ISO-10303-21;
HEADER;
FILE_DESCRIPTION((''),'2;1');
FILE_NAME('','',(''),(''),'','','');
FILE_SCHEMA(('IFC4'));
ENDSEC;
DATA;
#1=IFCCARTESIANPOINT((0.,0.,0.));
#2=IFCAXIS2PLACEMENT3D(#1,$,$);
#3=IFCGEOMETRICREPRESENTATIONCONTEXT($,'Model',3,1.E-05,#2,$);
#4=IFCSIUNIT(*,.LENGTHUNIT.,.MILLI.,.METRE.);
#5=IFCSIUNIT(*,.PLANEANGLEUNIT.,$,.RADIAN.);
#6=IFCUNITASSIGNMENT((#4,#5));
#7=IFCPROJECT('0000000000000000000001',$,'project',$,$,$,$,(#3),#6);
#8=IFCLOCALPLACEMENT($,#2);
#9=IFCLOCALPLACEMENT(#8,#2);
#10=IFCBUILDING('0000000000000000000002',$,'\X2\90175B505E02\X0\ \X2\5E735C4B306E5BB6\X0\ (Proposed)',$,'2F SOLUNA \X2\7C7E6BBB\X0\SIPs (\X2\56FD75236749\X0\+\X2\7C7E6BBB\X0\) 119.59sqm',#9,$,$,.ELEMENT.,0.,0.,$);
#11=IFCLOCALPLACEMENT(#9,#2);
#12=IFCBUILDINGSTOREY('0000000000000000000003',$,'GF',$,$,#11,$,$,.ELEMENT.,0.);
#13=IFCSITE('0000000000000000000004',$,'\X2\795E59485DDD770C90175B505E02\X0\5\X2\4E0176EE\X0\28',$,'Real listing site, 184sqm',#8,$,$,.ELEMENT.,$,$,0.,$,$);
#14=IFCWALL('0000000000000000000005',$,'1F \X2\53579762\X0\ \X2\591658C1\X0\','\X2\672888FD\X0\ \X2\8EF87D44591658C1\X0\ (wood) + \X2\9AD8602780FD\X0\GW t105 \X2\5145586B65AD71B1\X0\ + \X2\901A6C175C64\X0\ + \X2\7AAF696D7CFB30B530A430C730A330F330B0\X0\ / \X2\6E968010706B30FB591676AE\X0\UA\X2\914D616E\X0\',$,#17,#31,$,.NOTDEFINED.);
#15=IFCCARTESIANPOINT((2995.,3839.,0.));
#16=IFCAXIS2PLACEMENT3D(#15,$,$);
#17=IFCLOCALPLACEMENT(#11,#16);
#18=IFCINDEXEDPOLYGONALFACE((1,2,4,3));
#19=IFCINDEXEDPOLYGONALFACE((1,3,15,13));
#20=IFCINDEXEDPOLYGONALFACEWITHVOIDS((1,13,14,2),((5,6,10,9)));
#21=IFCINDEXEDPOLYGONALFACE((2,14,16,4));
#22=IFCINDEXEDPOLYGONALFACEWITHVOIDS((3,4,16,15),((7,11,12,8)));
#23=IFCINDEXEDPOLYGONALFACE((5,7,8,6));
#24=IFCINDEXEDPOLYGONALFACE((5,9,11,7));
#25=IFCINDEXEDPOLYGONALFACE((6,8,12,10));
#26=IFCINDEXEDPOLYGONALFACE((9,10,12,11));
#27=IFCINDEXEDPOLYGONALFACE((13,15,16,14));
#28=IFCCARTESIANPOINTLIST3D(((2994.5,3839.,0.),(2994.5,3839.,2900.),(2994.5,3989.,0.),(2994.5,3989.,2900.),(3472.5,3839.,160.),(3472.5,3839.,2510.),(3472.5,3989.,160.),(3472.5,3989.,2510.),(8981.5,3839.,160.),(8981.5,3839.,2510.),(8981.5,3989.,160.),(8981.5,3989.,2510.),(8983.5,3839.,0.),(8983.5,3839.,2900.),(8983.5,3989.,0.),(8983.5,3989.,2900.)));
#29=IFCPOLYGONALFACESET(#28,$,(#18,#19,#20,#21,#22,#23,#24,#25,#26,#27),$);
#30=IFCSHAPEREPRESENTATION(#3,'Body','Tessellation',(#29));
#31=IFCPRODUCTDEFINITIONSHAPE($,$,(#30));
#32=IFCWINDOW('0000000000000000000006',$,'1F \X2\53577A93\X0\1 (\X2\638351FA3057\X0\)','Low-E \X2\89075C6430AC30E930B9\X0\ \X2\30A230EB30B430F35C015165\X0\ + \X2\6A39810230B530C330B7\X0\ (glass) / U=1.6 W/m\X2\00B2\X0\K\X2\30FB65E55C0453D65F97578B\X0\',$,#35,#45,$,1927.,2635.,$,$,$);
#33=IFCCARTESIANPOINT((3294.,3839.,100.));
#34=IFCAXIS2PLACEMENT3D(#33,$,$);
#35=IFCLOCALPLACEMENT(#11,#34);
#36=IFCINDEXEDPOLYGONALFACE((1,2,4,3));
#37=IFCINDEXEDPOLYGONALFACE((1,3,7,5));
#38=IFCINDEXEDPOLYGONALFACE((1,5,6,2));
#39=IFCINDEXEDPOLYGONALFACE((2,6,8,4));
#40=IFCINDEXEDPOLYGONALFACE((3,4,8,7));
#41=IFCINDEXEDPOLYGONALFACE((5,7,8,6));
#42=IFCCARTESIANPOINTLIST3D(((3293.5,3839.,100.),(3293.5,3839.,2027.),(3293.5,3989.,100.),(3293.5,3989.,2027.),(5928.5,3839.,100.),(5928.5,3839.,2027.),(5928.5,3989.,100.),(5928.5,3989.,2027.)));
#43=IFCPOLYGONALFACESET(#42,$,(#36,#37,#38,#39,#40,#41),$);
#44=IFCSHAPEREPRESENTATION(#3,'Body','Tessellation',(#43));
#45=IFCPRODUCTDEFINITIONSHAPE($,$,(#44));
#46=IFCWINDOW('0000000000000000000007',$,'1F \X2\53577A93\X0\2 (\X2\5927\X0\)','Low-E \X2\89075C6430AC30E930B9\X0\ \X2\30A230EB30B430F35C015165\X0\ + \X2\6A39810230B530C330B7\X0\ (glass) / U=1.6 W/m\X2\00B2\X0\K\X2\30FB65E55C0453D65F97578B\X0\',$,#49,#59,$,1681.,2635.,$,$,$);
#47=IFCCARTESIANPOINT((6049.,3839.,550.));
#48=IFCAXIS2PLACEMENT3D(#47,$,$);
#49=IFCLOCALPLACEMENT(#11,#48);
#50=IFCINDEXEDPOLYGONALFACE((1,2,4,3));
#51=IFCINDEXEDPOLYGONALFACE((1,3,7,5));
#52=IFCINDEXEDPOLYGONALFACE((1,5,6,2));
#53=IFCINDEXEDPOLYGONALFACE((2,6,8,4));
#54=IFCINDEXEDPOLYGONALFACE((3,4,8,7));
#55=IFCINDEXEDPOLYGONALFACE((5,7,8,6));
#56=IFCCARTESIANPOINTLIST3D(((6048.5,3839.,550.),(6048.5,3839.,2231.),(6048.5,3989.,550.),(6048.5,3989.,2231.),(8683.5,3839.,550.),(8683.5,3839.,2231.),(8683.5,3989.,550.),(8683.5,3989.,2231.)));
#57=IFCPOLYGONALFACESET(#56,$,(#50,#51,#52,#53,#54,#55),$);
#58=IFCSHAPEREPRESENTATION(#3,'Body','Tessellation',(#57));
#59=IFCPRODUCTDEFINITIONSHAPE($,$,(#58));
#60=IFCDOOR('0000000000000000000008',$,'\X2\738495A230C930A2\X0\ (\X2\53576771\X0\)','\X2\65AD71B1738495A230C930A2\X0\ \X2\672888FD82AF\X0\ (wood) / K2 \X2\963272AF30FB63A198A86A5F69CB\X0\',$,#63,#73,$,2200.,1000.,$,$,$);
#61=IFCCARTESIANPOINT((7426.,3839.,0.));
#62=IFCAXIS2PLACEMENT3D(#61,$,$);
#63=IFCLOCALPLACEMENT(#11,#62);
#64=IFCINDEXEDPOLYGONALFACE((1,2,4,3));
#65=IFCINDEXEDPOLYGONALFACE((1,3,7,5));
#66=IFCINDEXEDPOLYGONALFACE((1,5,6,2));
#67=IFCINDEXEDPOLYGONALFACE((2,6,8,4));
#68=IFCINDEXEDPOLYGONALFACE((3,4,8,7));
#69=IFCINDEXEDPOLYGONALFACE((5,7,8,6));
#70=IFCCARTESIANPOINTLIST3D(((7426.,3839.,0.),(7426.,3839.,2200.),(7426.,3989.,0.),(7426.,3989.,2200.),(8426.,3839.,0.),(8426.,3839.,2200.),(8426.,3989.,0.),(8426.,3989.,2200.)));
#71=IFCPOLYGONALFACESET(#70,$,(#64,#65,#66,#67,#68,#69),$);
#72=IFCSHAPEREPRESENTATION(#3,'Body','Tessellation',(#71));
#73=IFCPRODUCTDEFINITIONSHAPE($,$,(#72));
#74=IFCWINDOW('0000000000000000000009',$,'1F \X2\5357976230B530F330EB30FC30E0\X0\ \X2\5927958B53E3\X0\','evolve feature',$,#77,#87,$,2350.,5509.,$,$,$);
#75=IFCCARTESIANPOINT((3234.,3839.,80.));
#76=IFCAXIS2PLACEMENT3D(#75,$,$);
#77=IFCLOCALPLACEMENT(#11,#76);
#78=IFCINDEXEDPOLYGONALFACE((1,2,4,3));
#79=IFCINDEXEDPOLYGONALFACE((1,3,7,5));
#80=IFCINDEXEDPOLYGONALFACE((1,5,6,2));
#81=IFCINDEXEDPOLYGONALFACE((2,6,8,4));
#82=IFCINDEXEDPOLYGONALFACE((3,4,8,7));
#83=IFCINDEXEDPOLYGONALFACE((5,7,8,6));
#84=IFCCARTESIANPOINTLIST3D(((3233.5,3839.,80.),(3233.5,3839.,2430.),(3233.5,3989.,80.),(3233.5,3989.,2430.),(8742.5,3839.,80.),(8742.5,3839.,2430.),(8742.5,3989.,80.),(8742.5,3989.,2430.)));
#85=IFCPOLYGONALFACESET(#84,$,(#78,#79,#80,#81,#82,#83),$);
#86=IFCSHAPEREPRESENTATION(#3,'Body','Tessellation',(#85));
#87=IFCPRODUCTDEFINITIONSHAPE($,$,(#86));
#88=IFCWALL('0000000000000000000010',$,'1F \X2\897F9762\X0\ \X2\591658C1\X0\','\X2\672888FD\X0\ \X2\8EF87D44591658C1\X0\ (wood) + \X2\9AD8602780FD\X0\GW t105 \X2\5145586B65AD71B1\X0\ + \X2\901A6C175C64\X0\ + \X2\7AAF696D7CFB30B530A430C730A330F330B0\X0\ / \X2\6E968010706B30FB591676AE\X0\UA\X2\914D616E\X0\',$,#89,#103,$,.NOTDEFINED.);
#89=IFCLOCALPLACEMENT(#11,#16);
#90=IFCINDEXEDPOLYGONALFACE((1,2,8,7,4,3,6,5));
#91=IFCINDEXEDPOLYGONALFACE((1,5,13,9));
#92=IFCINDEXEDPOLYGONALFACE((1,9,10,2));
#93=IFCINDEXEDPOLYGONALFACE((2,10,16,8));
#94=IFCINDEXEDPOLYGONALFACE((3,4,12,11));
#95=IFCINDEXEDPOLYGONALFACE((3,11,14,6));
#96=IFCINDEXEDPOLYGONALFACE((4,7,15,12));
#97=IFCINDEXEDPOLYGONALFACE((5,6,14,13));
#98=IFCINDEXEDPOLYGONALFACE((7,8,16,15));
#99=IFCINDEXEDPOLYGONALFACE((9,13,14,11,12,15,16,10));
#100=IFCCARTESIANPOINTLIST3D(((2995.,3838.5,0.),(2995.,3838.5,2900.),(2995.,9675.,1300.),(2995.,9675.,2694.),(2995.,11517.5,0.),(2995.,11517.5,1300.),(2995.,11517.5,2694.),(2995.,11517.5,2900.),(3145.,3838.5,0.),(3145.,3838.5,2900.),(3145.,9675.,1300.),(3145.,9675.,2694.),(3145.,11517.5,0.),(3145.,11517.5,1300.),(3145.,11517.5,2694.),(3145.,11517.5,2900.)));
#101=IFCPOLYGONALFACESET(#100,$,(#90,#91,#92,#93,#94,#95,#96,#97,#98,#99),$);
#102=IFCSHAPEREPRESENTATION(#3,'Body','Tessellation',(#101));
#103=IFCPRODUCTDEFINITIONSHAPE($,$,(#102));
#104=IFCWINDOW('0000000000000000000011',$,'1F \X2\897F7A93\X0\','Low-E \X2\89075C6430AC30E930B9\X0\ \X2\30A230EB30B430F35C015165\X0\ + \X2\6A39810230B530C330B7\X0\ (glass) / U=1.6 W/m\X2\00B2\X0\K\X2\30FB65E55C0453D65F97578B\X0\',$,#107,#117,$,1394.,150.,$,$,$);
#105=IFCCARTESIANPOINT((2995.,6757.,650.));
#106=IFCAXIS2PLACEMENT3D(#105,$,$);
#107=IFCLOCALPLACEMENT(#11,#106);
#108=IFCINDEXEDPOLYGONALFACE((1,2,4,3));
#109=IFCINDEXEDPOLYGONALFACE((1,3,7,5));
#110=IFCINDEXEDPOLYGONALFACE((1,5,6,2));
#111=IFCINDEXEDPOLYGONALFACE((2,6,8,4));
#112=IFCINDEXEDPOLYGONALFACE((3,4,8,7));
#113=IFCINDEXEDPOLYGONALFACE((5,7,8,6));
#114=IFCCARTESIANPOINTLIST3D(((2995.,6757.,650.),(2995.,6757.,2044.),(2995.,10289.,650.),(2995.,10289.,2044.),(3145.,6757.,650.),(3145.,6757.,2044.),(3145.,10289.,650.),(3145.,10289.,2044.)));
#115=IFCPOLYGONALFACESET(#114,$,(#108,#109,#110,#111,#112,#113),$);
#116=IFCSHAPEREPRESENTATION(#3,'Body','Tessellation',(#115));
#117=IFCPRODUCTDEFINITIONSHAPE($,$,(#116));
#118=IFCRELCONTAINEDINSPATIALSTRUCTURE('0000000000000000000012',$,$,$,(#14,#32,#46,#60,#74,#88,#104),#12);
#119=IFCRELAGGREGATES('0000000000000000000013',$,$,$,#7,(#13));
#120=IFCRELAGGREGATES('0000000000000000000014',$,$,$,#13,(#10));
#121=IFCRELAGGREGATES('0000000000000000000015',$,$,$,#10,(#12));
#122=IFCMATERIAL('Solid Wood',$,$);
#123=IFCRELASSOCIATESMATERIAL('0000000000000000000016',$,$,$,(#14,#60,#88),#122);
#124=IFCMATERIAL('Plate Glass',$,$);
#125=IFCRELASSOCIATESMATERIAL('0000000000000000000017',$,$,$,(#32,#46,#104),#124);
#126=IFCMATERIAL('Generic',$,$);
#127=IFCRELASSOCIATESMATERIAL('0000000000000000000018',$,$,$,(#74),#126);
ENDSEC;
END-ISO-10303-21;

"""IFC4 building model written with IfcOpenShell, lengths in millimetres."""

from ifc_helpers import new_model, si_unit, frame, frame_2d, origin, place, context, project, spatial, rectangle, extrude, material, element, fill, save


model = new_model("IFC4")

# Units and contexts
model_context = context("Model", 3, precision=1e-05, world=origin())
ifc_project = project(units=[si_unit("LENGTHUNIT", "METRE", prefix="MILLI"), si_unit("PLANEANGLEUNIT", "RADIAN")], contexts=[model_context])

# Site, building, storey
site_placement = place(None, origin())
site = spatial("IfcSite", under=ifc_project, at=site_placement, Name="神奈川県逗子市5丁目28", ObjectType="Real listing site, 184sqm", CompositionType="ELEMENT", RefElevation=0.0)
building_placement = place(site_placement, origin())
building = spatial("IfcBuilding", under=site, at=building_placement, Name="逗子市 平屋の家 (Proposed)", ObjectType="2F SOLUNA 籾殻SIPs (国産杉+籾殻) 119.59sqm", CompositionType="ELEMENT", ElevationOfRefHeight=0.0, ElevationOfTerrain=0.0)
storey_placement = place(building_placement, origin())
storey = spatial("IfcBuildingStorey", under=building, at=storey_placement, Name="GF", CompositionType="ELEMENT", Elevation=0.0)

# Shared definitions
ifc_material_1 = material(Name="Solid Wood")
ifc_material_2 = material(Name="Generic")

# Wall, openings, windows, door
wall_1_placement = place(storey_placement, frame((2995.0, 3839.0, 0.0)))
wall_1 = element("IfcWall", 1, at=wall_1_placement, inside=storey, material=ifc_material_1, Name="1F 南面 外壁", Description="木製 軸組外壁 (wood) + 高性能GW t105 充填断熱 + 通気層 + 窯業系サイディング / 準耐火・外皮UA配慮", PredefinedType="NOTDEFINED", context=model_context, shape_type="SweptSolid", body=[
    extrude(rectangle(XDim=5989.0, YDim=150.0, at=frame_2d((2994.0, 75.0))), frame((2995.0, 3839.0, 0.0)), (0.0, 0.0, 1.0), 2900.0),
])
opening_1_placement = place(storey_placement, frame((3294.0, 3839.0, 100.0)))
opening_1 = element("IfcOpeningElement", 2, at=opening_1_placement, cuts=wall_1, PredefinedType="NOTDEFINED", context=model_context, shape_type="SweptSolid", body=[
    extrude(rectangle(XDim=2635.0, YDim=150.0, at=frame_2d((1317.0, 75.0))), frame((3294.0, 3839.0, 100.0)), (0.0, 0.0, 1.0), 1927.0),
])
opening_2_placement = place(storey_placement, frame((6049.0, 3839.0, 550.0)))
opening_2 = element("IfcOpeningElement", 3, at=opening_2_placement, cuts=wall_1, PredefinedType="NOTDEFINED", context=model_context, shape_type="SweptSolid", body=[
    extrude(rectangle(XDim=2635.0, YDim=150.0, at=frame_2d((1317.0, 75.0))), frame((6049.0, 3839.0, 550.0)), (0.0, 0.0, 1.0), 1681.0),
])
opening_3_placement = place(storey_placement, frame((7426.0, 3839.0, 0.0)))
opening_3 = element("IfcOpeningElement", 4, at=opening_3_placement, cuts=wall_1, PredefinedType="NOTDEFINED", context=model_context, shape_type="SweptSolid", body=[
    extrude(rectangle(XDim=1000.0, YDim=150.0, at=frame_2d((500.0, 75.0))), frame((7426.0, 3839.0, 0.0)), (0.0, 0.0, 1.0), 2200.0),
])
opening_4_placement = place(storey_placement, frame((3234.0, 3839.0, 80.0)))
opening_4 = element("IfcOpeningElement", 5, at=opening_4_placement, cuts=wall_1, PredefinedType="NOTDEFINED", context=model_context, shape_type="SweptSolid", body=[
    extrude(rectangle(XDim=5509.0, YDim=150.0, at=frame_2d((2754.0, 75.0))), frame((3234.0, 3839.0, 80.0)), (0.0, 0.0, 1.0), 2350.0),
])
ifc_material_3 = material(Name="Plate Glass")
window_1_placement = place(storey_placement, frame((3294.0, 3839.0, 100.0)))
window_1 = element("IfcWindow", 6, at=window_1_placement, inside=storey, material=ifc_material_3, Name="1F 南窓1 (掃出し)", Description="Low-E 複層ガラス アルゴン封入 + 樹脂サッシ (glass) / U=1.6 W/m²K・日射取得型", OverallHeight=1927.0, OverallWidth=2635.0, context=model_context, shape_type="SweptSolid", body=[
    extrude(rectangle(XDim=2635.0, YDim=150.0, at=frame_2d((1317.0, 75.0))), frame((3294.0, 3839.0, 100.0)), (0.0, 0.0, 1.0), 1927.0),
])
fill(opening_1, window_1)
window_2_placement = place(storey_placement, frame((6049.0, 3839.0, 550.0)))
window_2 = element("IfcWindow", 7, at=window_2_placement, inside=storey, material=ifc_material_3, Name="1F 南窓2 (大)", Description="Low-E 複層ガラス アルゴン封入 + 樹脂サッシ (glass) / U=1.6 W/m²K・日射取得型", OverallHeight=1681.0, OverallWidth=2635.0, context=model_context, shape_type="SweptSolid", body=[
    extrude(rectangle(XDim=2635.0, YDim=150.0, at=frame_2d((1317.0, 75.0))), frame((6049.0, 3839.0, 550.0)), (0.0, 0.0, 1.0), 1681.0),
])
fill(opening_2, window_2)
door_placement = place(storey_placement, frame((7426.0, 3839.0, 0.0)))
door = element("IfcDoor", 8, at=door_placement, inside=storey, material=ifc_material_1, Name="玄関ドア (南東)", Description="断熱玄関ドア 木製芯 (wood) / K2 防犯・採風機構", OverallHeight=2200.0, OverallWidth=1000.0, context=model_context, shape_type="SweptSolid", body=[
    extrude(rectangle(XDim=1000.0, YDim=150.0, at=frame_2d((500.0, 75.0))), frame((7426.0, 3839.0, 0.0)), (0.0, 0.0, 1.0), 2200.0),
])
fill(opening_3, door)
window_3_placement = place(storey_placement, frame((3234.0, 3839.0, 80.0)))
window_3 = element("IfcWindow", 9, at=window_3_placement, inside=storey, material=ifc_material_2, Name="1F 南面サンルーム 大開口", Description="evolve feature", OverallHeight=2350.0, OverallWidth=5509.0, context=model_context, shape_type="SweptSolid", body=[
    extrude(rectangle(XDim=5509.0, YDim=150.0, at=frame_2d((2754.0, 75.0))), frame((3234.0, 3839.0, 80.0)), (0.0, 0.0, 1.0), 2350.0),
])
fill(opening_4, window_3)

# Wall, opening, window
wall_2_placement = place(storey_placement, frame((2995.0, 3839.0, 0.0)))
wall_2 = element("IfcWall", 10, at=wall_2_placement, inside=storey, material=ifc_material_1, Name="1F 西面 外壁", Description="木製 軸組外壁 (wood) + 高性能GW t105 充填断熱 + 通気層 + 窯業系サイディング / 準耐火・外皮UA配慮", PredefinedType="NOTDEFINED", context=model_context, shape_type="SweptSolid", body=[
    extrude(rectangle(XDim=150.0, YDim=7679.0, at=frame_2d((75.0, 3839.0))), frame((2995.0, 3839.0, 0.0)), (0.0, 0.0, 1.0), 2900.0),
])
opening_5_placement = place(storey_placement, frame((2995.0, 6757.0, 650.0)))
opening_5 = element("IfcOpeningElement", 11, at=opening_5_placement, cuts=wall_2, PredefinedType="NOTDEFINED", context=model_context, shape_type="SweptSolid", body=[
    extrude(rectangle(XDim=150.0, YDim=3532.0, at=frame_2d((75.0, 1766.0))), frame((2995.0, 6757.0, 650.0)), (0.0, 0.0, 1.0), 1394.0),
])
window_4_placement = place(storey_placement, frame((2995.0, 6757.0, 650.0)))
window_4 = element("IfcWindow", 12, at=window_4_placement, inside=storey, material=ifc_material_3, Name="1F 西窓", Description="Low-E 複層ガラス アルゴン封入 + 樹脂サッシ (glass) / U=1.6 W/m²K・日射取得型", OverallHeight=1394.0, OverallWidth=150.0, context=model_context, shape_type="SweptSolid", body=[
    extrude(rectangle(XDim=150.0, YDim=3532.0, at=frame_2d((75.0, 1766.0))), frame((2995.0, 6757.0, 650.0)), (0.0, 0.0, 1.0), 1394.0),
])
fill(opening_5, window_4)

save(model, "model.ifc")
